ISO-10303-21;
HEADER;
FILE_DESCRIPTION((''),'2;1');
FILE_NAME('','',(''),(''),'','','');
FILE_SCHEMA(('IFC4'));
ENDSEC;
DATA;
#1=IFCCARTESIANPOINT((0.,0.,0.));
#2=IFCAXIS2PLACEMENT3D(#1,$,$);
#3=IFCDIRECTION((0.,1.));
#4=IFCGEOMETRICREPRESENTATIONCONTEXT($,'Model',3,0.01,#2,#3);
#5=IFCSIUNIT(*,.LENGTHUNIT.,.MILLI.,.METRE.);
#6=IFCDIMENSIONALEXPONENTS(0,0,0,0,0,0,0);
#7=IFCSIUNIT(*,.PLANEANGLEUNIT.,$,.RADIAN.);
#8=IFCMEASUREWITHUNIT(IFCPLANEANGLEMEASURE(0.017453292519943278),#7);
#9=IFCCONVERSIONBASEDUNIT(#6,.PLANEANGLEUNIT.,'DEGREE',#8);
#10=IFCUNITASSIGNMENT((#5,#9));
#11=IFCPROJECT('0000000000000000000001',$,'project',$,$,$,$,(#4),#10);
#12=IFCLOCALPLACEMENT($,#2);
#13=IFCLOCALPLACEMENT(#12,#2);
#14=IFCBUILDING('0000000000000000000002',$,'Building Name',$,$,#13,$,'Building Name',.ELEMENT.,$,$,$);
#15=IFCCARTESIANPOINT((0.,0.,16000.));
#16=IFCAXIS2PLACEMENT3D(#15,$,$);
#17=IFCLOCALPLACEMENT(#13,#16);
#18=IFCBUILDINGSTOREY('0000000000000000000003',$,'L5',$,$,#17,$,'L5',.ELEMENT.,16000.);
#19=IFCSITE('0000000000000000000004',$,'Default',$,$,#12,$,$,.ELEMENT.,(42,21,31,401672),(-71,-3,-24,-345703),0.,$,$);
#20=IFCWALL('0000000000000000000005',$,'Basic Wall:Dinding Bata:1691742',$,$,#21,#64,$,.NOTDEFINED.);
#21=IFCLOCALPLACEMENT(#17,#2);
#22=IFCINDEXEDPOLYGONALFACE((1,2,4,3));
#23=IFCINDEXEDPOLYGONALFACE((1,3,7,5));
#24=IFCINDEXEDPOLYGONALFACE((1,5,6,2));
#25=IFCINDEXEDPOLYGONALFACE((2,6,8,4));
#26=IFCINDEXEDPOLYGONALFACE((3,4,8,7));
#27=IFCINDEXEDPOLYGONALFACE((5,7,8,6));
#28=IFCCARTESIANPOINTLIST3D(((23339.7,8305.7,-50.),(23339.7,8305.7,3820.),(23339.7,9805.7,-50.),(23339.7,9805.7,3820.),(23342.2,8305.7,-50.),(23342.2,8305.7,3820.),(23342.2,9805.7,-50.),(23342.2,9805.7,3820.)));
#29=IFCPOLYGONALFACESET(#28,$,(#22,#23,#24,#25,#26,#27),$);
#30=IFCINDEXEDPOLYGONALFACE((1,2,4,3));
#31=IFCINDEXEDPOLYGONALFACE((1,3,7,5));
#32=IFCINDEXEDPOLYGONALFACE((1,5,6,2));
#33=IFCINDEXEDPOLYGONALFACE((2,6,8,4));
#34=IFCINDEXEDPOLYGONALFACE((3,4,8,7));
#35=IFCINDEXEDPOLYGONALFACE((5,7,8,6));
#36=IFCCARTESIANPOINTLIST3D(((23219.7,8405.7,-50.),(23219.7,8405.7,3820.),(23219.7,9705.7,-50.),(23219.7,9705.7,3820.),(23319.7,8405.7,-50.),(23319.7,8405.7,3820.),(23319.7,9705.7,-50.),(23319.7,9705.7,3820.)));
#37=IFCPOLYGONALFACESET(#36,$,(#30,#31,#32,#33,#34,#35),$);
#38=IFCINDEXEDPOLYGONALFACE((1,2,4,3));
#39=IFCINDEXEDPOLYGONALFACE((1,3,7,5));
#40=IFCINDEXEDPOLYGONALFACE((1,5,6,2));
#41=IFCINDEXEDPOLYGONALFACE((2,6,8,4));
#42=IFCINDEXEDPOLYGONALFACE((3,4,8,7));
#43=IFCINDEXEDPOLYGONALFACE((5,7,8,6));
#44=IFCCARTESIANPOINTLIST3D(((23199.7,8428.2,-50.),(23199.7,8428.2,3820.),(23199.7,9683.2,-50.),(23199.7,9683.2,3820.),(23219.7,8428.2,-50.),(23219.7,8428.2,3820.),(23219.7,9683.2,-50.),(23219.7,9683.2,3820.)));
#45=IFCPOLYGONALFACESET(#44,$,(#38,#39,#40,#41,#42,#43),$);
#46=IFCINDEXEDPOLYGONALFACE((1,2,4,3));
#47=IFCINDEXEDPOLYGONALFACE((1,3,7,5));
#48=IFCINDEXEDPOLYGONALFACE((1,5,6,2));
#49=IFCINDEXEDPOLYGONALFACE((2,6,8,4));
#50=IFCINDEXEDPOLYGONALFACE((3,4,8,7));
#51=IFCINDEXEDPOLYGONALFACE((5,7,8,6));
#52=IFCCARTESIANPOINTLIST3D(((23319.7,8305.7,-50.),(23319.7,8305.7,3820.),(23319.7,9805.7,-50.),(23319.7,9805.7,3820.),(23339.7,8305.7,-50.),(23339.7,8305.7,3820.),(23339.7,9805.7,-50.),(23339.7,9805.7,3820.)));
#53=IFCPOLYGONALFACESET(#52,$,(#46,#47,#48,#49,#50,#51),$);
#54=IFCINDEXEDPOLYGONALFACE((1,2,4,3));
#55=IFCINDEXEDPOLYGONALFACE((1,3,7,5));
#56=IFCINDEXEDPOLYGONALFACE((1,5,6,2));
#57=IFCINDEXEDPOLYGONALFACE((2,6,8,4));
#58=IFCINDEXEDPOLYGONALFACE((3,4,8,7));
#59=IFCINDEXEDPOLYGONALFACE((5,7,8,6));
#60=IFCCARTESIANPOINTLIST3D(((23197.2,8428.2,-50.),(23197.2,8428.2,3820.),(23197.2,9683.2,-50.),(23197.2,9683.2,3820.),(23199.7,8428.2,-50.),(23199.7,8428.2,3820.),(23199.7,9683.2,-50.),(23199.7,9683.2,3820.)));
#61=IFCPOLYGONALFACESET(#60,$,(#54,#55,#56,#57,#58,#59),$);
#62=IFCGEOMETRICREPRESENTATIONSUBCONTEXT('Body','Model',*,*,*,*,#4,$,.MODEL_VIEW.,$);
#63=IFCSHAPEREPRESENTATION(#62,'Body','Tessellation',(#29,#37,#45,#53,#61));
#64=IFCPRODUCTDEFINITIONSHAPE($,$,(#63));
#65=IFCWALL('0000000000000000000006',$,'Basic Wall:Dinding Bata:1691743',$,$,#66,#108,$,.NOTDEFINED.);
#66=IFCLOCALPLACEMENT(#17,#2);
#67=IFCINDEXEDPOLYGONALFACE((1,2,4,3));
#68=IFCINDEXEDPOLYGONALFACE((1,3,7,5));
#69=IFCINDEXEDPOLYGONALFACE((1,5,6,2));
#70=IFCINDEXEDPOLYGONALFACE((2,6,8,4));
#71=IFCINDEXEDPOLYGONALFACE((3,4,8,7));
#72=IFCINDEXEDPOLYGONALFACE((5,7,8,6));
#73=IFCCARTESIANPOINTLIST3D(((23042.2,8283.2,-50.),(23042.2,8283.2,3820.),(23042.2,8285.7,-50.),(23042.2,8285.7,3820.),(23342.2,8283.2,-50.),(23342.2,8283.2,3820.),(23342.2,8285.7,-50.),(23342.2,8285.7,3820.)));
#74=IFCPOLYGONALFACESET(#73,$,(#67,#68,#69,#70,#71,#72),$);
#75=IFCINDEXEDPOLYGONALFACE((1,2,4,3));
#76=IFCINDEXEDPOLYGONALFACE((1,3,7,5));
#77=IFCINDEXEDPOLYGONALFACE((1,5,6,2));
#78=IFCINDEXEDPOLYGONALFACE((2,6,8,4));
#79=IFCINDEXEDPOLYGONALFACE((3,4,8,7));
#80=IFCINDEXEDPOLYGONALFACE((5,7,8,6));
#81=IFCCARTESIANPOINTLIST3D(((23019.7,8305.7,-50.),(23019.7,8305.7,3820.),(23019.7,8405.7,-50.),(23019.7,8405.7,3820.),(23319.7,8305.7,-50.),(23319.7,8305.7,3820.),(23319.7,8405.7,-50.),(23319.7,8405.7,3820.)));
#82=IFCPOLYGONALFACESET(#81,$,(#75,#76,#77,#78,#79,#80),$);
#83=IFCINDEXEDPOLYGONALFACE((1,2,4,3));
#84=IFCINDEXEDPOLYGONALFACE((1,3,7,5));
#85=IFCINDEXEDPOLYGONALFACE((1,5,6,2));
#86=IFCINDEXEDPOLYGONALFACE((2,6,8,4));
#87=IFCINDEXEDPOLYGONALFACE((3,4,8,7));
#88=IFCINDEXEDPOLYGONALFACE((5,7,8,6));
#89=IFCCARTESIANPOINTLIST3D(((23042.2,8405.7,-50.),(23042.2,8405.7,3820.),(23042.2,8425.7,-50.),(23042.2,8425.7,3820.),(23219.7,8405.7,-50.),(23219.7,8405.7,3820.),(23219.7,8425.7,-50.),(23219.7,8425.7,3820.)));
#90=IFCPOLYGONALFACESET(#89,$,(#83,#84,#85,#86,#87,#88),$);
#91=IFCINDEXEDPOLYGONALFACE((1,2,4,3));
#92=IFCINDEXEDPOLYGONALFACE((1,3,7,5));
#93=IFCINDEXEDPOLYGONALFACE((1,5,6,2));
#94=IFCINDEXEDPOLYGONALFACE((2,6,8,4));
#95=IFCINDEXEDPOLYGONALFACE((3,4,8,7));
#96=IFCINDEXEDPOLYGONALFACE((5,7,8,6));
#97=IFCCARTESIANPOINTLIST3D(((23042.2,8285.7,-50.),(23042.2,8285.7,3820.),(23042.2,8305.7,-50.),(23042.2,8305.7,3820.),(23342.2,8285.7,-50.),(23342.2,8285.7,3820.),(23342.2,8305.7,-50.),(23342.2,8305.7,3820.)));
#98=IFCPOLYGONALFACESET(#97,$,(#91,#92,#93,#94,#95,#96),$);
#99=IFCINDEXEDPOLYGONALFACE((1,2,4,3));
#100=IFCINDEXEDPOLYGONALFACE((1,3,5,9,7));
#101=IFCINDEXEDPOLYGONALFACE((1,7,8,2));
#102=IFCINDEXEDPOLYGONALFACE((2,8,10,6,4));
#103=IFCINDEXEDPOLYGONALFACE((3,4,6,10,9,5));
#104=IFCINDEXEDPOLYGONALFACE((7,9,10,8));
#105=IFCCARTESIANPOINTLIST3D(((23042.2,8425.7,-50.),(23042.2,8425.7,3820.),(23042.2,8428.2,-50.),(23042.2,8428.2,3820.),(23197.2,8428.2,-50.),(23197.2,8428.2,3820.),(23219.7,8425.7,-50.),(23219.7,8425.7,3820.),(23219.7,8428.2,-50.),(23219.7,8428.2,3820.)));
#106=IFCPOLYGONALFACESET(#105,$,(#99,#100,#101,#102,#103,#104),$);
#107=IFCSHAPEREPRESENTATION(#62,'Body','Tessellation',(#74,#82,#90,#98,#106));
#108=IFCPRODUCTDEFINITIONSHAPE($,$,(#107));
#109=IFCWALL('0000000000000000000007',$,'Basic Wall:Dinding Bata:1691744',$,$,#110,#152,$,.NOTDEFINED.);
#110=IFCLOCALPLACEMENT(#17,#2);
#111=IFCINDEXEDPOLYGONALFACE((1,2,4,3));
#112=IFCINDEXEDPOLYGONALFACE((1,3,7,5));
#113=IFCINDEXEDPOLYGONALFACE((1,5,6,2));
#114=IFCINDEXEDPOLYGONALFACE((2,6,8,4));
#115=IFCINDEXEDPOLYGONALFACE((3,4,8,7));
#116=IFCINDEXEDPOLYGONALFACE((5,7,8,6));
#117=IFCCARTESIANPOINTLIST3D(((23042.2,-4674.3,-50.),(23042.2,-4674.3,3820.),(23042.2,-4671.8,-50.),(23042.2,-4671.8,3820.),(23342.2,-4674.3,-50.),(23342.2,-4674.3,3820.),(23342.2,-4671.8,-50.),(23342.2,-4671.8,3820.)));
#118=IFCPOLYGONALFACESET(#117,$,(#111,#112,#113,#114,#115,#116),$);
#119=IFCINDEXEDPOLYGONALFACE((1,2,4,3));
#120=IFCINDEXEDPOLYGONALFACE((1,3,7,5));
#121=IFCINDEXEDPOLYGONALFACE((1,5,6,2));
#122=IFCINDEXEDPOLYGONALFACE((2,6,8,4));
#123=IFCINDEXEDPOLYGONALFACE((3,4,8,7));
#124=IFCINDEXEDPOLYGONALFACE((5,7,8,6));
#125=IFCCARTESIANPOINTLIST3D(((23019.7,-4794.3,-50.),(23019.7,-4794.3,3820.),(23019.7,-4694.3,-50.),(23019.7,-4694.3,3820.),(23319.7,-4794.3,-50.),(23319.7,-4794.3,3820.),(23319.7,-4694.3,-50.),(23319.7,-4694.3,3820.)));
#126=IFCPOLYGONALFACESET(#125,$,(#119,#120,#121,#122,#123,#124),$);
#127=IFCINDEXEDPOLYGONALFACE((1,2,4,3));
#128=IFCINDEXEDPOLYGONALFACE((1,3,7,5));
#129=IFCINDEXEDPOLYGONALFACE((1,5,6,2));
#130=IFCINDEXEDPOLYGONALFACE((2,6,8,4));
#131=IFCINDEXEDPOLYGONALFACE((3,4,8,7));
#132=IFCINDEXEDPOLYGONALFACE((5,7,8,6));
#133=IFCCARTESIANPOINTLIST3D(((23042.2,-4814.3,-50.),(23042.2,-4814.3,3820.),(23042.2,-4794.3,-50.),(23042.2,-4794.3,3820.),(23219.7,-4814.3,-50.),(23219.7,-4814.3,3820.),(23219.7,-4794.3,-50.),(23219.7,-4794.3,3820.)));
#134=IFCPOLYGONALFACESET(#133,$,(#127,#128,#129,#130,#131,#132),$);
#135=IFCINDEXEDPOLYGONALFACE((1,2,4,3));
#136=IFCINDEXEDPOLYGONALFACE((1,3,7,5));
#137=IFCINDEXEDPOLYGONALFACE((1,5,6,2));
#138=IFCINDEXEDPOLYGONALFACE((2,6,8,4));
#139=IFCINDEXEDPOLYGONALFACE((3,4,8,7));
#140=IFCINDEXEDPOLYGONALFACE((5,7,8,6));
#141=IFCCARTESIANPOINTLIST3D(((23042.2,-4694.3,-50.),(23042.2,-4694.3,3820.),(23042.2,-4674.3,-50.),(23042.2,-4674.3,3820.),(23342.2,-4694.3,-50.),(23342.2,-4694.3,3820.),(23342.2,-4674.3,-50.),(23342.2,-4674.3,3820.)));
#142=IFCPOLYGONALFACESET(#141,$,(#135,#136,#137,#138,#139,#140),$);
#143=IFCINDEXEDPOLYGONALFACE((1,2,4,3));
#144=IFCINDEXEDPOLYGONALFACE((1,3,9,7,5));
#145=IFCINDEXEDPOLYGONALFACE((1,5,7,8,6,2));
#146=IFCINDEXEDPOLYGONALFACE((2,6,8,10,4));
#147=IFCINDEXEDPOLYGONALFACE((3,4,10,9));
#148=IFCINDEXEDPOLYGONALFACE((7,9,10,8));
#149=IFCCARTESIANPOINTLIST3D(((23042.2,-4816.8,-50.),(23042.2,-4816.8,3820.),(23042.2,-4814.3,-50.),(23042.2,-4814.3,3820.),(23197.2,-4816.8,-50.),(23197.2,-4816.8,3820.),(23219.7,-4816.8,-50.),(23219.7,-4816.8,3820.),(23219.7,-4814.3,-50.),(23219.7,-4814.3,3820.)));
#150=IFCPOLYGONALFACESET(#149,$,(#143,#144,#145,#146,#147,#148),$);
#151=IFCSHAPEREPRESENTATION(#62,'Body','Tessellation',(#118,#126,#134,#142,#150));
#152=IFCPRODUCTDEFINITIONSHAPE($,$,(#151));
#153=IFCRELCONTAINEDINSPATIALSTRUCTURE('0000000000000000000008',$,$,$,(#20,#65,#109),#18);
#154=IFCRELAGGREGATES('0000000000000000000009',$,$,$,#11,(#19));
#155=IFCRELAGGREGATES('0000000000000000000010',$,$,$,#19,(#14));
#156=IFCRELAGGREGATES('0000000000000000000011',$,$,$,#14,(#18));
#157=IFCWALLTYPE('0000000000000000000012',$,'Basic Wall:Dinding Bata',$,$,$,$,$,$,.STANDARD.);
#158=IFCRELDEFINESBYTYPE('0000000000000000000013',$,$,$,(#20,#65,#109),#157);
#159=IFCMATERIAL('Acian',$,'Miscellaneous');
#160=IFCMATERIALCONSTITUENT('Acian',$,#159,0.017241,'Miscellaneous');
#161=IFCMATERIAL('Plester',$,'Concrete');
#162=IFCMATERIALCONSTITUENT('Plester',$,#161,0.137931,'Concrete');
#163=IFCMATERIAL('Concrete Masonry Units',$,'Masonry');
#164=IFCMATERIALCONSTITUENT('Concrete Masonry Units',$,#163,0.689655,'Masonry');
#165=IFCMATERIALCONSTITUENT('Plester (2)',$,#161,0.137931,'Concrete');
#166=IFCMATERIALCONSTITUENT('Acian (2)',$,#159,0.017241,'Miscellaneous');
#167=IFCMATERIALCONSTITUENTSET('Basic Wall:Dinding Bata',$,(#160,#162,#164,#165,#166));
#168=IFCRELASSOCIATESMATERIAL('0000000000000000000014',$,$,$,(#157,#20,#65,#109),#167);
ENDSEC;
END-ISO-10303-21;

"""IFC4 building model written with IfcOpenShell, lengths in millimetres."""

from ifc_helpers import new_model, entity, si_unit, converted_unit, direction, frame, origin, place, context, subcontext, project, spatial, indexed_curve, outline, extrude, material, constituent, constituent_set, type_object, element, save


model = new_model("IFC4")

# Units and contexts
model_context = context("Model", 3, precision=0.01, world=origin(), true_north=direction((0.0, 1.0)))
body_context = subcontext(model_context, "Body", "Model", "MODEL_VIEW")
ifc_project = project(units=[si_unit("LENGTHUNIT", "METRE", prefix="MILLI"), converted_unit("PLANEANGLEUNIT", "DEGREE", entity("IfcPlaneAngleMeasure", 0.017453292519943278), si_unit("PLANEANGLEUNIT", "RADIAN"), dimensions=[0, 0, 0, 0, 0, 0, 0])], contexts=[model_context])

# Site, building, storey
site_placement = place(None, origin())
site = spatial("IfcSite", under=ifc_project, at=site_placement, Name="Default", CompositionType="ELEMENT", RefLatitude=(42, 21, 31, 401672), RefLongitude=(-71, -3, -24, -345703), RefElevation=0.0)
building_placement = place(site_placement, origin())
building = spatial("IfcBuilding", under=site, at=building_placement, Name="Building Name", LongName="Building Name", CompositionType="ELEMENT")
storey_placement = place(building_placement, frame((0.0, 0.0, 16000.0)))
storey = spatial("IfcBuildingStorey", under=building, at=storey_placement, Name="L5", LongName="L5", CompositionType="ELEMENT", Elevation=16000.0)

# Walls
ifc_material_1 = material(Name="Acian", Category="Miscellaneous")
ifc_constituent_1 = constituent(ifc_material_1, Name="Acian", Category="Miscellaneous", fraction=0.017241)
ifc_material_2 = material(Name="Plester", Category="Concrete")
ifc_constituent_2 = constituent(ifc_material_2, Name="Plester", Category="Concrete", fraction=0.137931)
ifc_material_3 = material(Name="Concrete Masonry Units", Category="Masonry")
ifc_constituent_3 = constituent(ifc_material_3, Name="Concrete Masonry Units", Category="Masonry", fraction=0.689655)
ifc_constituent_4 = constituent(ifc_material_2, Name="Plester (2)", Category="Concrete", fraction=0.137931)
ifc_constituent_5 = constituent(ifc_material_1, Name="Acian (2)", Category="Miscellaneous", fraction=0.017241)
ifc_constituent_set = constituent_set(constituents=[ifc_constituent_1, ifc_constituent_2, ifc_constituent_3, ifc_constituent_4, ifc_constituent_5], Name="Basic Wall:Dinding Bata")
wall_type = type_object("IfcWallType", Name="Basic Wall:Dinding Bata", PredefinedType="STANDARD", material=ifc_constituent_set)
wall_1_placement = place(storey_placement, frame((23269.7, 9683.2, -50.0), z_axis=(0.0, 0.0, 1.0), x_axis=(0.0, -1.0, 0.0)))
element("IfcWall", 1, at=wall_1_placement, inside=storey, type_object=wall_type, material=ifc_constituent_set, Name="Basic Wall:Dinding Bata:1691742", PredefinedType="NOTDEFINED", context=body_context, shape_type="SweptSolid", body=[
    extrude(outline(indexed_curve([(-1.2, -750.0), (1.2, -750.0), (1.3, 750.0), (-1.2, 750.0), (-1.2, -750.0)], self_intersect=False)), frame((627.5, 71.3, 0.0), z_axis=(0.0, 0.0, 1.0), x_axis=(0.0, -1.0, 0.0)), (0.0, 0.0, 1.0), 3870.0),
    extrude(outline(indexed_curve([(-650.0, -50.0), (650.0, -50.0), (650.0, 50.0), (-650.0, 50.0), (-650.0, -50.0)], self_intersect=False)), frame((627.5, 0.0, 0.0)), (0.0, 0.0, 1.0), 3870.0),
    extrude(outline(indexed_curve([(-627.5, -10.0), (627.5, -10.0), (627.5, 10.0), (-627.5, 10.0), (-627.5, -10.0)], self_intersect=False)), frame((627.5, -60.0, 0.0)), (0.0, 0.0, 1.0), 3870.0),
    extrude(outline(indexed_curve([(-750.0, -10.0), (750.0, -10.0), (750.0, 10.0), (-750.0, 10.0), (-750.0, -10.0)], self_intersect=False)), frame((627.5, 60.0, 0.0)), (0.0, 0.0, 1.0), 3870.0),
    extrude(outline(indexed_curve([(-1.3, -627.5), (1.2, -627.5), (1.2, 627.5), (-1.2, 627.5), (-1.3, -627.5)], self_intersect=False)), frame((627.5, -71.2, 0.0), z_axis=(0.0, 0.0, 1.0), x_axis=(0.0, 1.0, 0.0)), (0.0, 0.0, 1.0), 3870.0),
])
wall_2_placement = place(storey_placement, frame((23342.2, 8355.7, -50.0), z_axis=(0.0, 0.0, 1.0), x_axis=(-1.0, 0.0, 0.0)))
element("IfcWall", 2, at=wall_2_placement, inside=storey, type_object=wall_type, material=ifc_constituent_set, Name="Basic Wall:Dinding Bata:1691743", PredefinedType="NOTDEFINED", context=body_context, shape_type="SweptSolid", body=[
    extrude(outline(indexed_curve([(-1.3, -150.0), (1.2, -150.0), (1.2, 150.0), (-1.2, 150.0), (-1.3, -150.0)], self_intersect=False)), frame((150.0, 71.3, 0.0), z_axis=(0.0, 0.0, 1.0), x_axis=(0.0, -1.0, 0.0)), (0.0, 0.0, 1.0), 3870.0),
    extrude(outline(indexed_curve([(-150.0, -50.0), (150.0, -50.0), (150.0, 50.0), (-150.0, 50.0), (-150.0, -50.0)], self_intersect=False)), frame((172.5, 0.0, 0.0)), (0.0, 0.0, 1.0), 3870.0),
    extrude(outline(indexed_curve([(-88.8, -10.0), (88.8, -10.0), (88.8, 10.0), (-88.8, 10.0), (-88.8, -10.0)], self_intersect=False)), frame((211.3, -60.0, 0.0)), (0.0, 0.0, 1.0), 3870.0),
    extrude(outline(indexed_curve([(-150.0, -10.0), (150.0, -10.0), (150.0, 10.0), (-150.0, 10.0), (-150.0, -10.0)], self_intersect=False)), frame((150.0, 60.0, 0.0)), (0.0, 0.0, 1.0), 3870.0),
    extrude(outline(indexed_curve([(-53.0, -1.0), (102.0, -1.0), (102.0, 1.5), (-75.5, 1.5), (-75.5, -1.0), (-53.0, -1.0)], self_intersect=False)), frame((198.0, -71.5, 0.0)), (0.0, 0.0, 1.0), 3870.0),
])
wall_3_placement = place(storey_placement, frame((23042.2, -4744.3, -50.0)))
element("IfcWall", 3, at=wall_3_placement, inside=storey, type_object=wall_type, material=ifc_constituent_set, Name="Basic Wall:Dinding Bata:1691744", PredefinedType="NOTDEFINED", context=body_context, shape_type="SweptSolid", body=[
    extrude(outline(indexed_curve([(-1.3, -150.0), (1.2, -150.0), (1.3, 150.0), (-1.2, 150.0), (-1.3, -150.0)], self_intersect=False)), frame((150.0, 71.3, 0.0), z_axis=(0.0, 0.0, 1.0), x_axis=(0.0, -1.0, 0.0)), (0.0, 0.0, 1.0), 3870.0),
    extrude(outline(indexed_curve([(-150.0, -50.0), (150.0, -50.0), (150.0, 50.0), (-150.0, 50.0), (-150.0, -50.0)], self_intersect=False)), frame((127.5, 0.0, 0.0)), (0.0, 0.0, 1.0), 3870.0),
    extrude(outline(indexed_curve([(-88.8, -10.0), (88.8, -10.0), (88.8, 10.0), (-88.8, 10.0), (-88.8, -10.0)], self_intersect=False)), frame((88.8, -60.0, 0.0)), (0.0, 0.0, 1.0), 3870.0),
    extrude(outline(indexed_curve([(-150.0, -10.0), (150.0, -10.0), (150.0, 10.0), (-150.0, 10.0), (-150.0, -10.0)], self_intersect=False)), frame((150.0, 60.0, 0.0)), (0.0, 0.0, 1.0), 3870.0),
    extrude(outline(indexed_curve([(53.0, -1.0), (75.5, -1.0), (75.5, 1.5), (-102.0, 1.5), (-102.0, -1.0), (53.0, -1.0)], self_intersect=False)), frame((102.0, -71.5, 0.0)), (0.0, 0.0, 1.0), 3870.0),
])

save(model, "model.ifc")
